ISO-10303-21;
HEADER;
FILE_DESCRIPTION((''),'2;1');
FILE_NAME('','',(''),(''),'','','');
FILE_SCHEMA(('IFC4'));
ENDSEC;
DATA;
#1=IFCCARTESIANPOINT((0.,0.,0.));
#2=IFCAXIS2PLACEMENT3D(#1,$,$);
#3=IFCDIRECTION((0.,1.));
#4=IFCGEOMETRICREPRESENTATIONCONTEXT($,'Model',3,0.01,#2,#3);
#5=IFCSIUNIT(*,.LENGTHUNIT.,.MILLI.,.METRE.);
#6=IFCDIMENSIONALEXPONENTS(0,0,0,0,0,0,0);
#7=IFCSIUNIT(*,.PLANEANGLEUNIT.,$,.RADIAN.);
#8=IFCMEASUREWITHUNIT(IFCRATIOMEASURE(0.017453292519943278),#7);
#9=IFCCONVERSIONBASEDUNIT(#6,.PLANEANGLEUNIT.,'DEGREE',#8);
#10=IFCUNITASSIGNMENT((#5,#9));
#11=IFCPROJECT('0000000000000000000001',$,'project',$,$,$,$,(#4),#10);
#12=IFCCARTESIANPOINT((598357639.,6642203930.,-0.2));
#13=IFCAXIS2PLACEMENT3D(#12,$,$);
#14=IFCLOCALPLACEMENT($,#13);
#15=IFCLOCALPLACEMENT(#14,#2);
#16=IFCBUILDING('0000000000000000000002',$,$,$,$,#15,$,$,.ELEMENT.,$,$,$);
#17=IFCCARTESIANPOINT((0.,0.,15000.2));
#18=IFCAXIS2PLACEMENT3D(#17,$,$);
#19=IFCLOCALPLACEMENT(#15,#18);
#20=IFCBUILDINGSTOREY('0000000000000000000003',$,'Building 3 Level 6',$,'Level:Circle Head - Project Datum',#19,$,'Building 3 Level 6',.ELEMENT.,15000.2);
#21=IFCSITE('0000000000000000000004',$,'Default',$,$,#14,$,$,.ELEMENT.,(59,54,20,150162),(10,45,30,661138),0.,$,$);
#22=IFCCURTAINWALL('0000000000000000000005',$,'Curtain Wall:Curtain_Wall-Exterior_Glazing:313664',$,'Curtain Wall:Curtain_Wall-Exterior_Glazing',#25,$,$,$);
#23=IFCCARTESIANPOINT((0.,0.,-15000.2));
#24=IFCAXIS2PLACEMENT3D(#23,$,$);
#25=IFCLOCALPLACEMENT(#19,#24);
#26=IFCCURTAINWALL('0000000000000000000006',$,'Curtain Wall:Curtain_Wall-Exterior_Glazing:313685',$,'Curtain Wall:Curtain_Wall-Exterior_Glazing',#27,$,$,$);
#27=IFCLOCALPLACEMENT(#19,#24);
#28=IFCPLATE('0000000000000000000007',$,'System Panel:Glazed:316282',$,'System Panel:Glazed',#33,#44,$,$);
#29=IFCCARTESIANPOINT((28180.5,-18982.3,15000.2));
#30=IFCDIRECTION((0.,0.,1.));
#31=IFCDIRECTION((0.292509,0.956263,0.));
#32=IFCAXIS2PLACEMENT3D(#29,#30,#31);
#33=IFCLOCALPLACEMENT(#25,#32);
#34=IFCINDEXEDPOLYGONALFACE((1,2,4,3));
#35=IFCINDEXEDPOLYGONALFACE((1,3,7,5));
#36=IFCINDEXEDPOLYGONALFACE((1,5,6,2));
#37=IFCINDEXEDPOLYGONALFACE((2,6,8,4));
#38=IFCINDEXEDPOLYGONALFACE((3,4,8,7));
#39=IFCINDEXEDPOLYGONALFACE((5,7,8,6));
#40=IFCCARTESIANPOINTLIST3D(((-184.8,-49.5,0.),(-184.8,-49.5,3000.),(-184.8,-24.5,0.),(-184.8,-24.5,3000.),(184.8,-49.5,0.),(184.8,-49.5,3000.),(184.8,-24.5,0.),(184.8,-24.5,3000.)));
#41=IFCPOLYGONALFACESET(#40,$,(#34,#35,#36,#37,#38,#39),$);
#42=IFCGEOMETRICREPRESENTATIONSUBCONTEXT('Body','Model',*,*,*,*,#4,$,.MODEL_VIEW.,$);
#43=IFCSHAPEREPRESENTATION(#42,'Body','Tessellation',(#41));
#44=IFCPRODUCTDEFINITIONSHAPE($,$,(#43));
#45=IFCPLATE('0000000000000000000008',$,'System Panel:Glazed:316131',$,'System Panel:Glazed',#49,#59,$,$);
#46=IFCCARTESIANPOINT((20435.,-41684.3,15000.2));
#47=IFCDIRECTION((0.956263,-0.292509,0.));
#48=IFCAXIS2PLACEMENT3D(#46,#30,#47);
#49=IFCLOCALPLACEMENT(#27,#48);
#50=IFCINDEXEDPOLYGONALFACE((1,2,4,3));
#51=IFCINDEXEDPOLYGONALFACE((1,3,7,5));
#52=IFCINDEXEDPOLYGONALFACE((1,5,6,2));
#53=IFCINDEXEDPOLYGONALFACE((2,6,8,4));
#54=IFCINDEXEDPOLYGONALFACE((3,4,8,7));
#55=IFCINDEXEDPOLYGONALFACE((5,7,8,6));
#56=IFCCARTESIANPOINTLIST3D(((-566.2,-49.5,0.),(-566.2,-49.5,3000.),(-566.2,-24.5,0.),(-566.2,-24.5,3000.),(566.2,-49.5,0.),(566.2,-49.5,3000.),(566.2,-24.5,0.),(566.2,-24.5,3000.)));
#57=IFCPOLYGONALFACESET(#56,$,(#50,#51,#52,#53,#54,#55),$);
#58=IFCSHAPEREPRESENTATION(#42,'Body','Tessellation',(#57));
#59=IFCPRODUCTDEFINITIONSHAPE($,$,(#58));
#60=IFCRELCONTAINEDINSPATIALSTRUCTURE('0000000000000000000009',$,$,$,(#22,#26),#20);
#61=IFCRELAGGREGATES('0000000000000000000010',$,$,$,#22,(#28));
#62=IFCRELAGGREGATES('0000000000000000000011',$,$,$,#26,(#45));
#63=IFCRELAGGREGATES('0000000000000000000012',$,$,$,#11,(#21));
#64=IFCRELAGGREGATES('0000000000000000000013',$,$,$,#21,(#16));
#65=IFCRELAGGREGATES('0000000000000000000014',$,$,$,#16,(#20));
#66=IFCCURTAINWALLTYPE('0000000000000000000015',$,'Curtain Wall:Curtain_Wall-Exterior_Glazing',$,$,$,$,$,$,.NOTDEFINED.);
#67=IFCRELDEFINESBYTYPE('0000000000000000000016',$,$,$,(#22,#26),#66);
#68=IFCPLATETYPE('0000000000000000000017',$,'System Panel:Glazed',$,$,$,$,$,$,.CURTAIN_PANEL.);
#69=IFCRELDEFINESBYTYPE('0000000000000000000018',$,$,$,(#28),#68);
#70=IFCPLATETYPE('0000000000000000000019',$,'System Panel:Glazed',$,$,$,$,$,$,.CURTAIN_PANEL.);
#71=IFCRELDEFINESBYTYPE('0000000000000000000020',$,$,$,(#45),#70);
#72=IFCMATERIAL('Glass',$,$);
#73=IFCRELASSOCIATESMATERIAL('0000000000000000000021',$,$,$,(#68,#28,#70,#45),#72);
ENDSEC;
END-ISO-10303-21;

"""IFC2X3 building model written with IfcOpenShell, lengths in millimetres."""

from ifc_helpers import new_model, entity, si_unit, converted_unit, direction, frame, frame_2d, origin, place, context, subcontext, project, spatial, rectangle, extrude, source, transform, mapped, material, type_object, type_shapes, element, aggregate, save


model = new_model("IFC2X3")

# Units and contexts
model_context = context("Model", 3, precision=0.01, world=origin(), true_north=direction((0.0, 1.0)))
body_context = subcontext(model_context, "Body", "Model", "MODEL_VIEW")
ifc_project = project(units=[si_unit("LENGTHUNIT", "METRE", prefix="MILLI"), converted_unit("PLANEANGLEUNIT", "DEGREE", entity("IfcRatioMeasure", 0.017453292519943278), si_unit("PLANEANGLEUNIT", "RADIAN"), dimensions=[0, 0, 0, 0, 0, 0, 0])], contexts=[model_context])

# Site, building, storey
site_placement = place(None, frame((598357639.0, 6642203930.0, -0.2)))
site = spatial("IfcSite", under=ifc_project, at=site_placement, Name="Default", CompositionType="ELEMENT", RefLatitude=(59, 54, 20, 150162), RefLongitude=(10, 45, 30, 661138), RefElevation=0.0)
building_placement = place(site_placement, origin())
building = spatial("IfcBuilding", under=site, at=building_placement, CompositionType="ELEMENT")
storey_placement = place(building_placement, frame((0.0, 0.0, 15000.2)))
storey = spatial("IfcBuildingStorey", under=building, at=storey_placement, Name="Building 3 Level 6", ObjectType="Level:Circle Head - Project Datum", LongName="Building 3 Level 6", CompositionType="ELEMENT", Elevation=15000.2)

# Curtain walls
curtain_wall_type = type_object("IfcCurtainWallType", Name="Curtain Wall:Curtain_Wall-Exterior_Glazing", PredefinedType="NOTDEFINED")
curtain_wall_1_placement = place(storey_placement, frame((0.0, 0.0, -15000.2)))
curtain_wall_1 = element("IfcCurtainWall", 1, at=curtain_wall_1_placement, inside=storey, type_object=curtain_wall_type, Name="Curtain Wall:Curtain_Wall-Exterior_Glazing:313664", ObjectType="Curtain Wall:Curtain_Wall-Exterior_Glazing")
ifc_material_1 = material(Name="Glass")
curtain_wall_2_placement = place(storey_placement, frame((0.0, 0.0, -15000.2)))
curtain_wall_2 = element("IfcCurtainWall", 2, at=curtain_wall_2_placement, inside=storey, type_object=curtain_wall_type, Name="Curtain Wall:Curtain_Wall-Exterior_Glazing:313685", ObjectType="Curtain Wall:Curtain_Wall-Exterior_Glazing")

# Plates
plate_type_1 = type_object("IfcPlateType", Name="System Panel:Glazed", PredefinedType="CURTAIN_PANEL", material=ifc_material_1)
shared_shape_1 = source(origin(), body_context, "Body", "SweptSolid", [
    extrude(rectangle(XDim=25.0, YDim=369.6, at=frame_2d((0.0, 0.0), x_axis=(1.0, 0.0))), frame((0.0, -37.0, 0.0), z_axis=(0.0, 0.0, 1.0), x_axis=(0.0, 1.0, 0.0)), (0.0, 0.0, 1.0), 3000.0),
])
type_shapes(plate_type_1, [shared_shape_1])
plate_1_placement = place(curtain_wall_1_placement, frame((28180.5, -18982.3, 15000.2), z_axis=(0.0, 0.0, 1.0), x_axis=(0.292509, 0.956263, 0.0)))
plate_1 = element("IfcPlate", 3, at=plate_1_placement, type_object=plate_type_1, material=ifc_material_1, Name="System Panel:Glazed:316282", ObjectType="System Panel:Glazed", context=body_context, shape_type="MappedRepresentation", body=[
    mapped(shared_shape_1, transform((0.0, 0.0, 0.0), scale=1.0)),
])
aggregate(curtain_wall_1, [plate_1])
plate_type_2 = type_object("IfcPlateType", Name="System Panel:Glazed", PredefinedType="CURTAIN_PANEL", material=ifc_material_1)
shared_shape_2 = source(origin(), body_context, "Body", "SweptSolid", [
    extrude(rectangle(XDim=25.0, YDim=1132.3, at=frame_2d((0.0, 0.0), x_axis=(1.0, 0.0))), frame((0.0, -37.0, 0.0), z_axis=(0.0, 0.0, 1.0), x_axis=(0.0, 1.0, 0.0)), (0.0, 0.0, 1.0), 3000.0),
])
type_shapes(plate_type_2, [shared_shape_2])
plate_2_placement = place(curtain_wall_2_placement, frame((20435.0, -41684.3, 15000.2), z_axis=(0.0, 0.0, 1.0), x_axis=(0.956263, -0.292509, 0.0)))
plate_2 = element("IfcPlate", 4, at=plate_2_placement, type_object=plate_type_2, material=ifc_material_1, Name="System Panel:Glazed:316131", ObjectType="System Panel:Glazed", context=body_context, shape_type="MappedRepresentation", body=[
    mapped(shared_shape_2, transform((0.0, 0.0, 0.0), scale=1.0)),
])
aggregate(curtain_wall_2, [plate_2])

save(model, "model.ifc")
